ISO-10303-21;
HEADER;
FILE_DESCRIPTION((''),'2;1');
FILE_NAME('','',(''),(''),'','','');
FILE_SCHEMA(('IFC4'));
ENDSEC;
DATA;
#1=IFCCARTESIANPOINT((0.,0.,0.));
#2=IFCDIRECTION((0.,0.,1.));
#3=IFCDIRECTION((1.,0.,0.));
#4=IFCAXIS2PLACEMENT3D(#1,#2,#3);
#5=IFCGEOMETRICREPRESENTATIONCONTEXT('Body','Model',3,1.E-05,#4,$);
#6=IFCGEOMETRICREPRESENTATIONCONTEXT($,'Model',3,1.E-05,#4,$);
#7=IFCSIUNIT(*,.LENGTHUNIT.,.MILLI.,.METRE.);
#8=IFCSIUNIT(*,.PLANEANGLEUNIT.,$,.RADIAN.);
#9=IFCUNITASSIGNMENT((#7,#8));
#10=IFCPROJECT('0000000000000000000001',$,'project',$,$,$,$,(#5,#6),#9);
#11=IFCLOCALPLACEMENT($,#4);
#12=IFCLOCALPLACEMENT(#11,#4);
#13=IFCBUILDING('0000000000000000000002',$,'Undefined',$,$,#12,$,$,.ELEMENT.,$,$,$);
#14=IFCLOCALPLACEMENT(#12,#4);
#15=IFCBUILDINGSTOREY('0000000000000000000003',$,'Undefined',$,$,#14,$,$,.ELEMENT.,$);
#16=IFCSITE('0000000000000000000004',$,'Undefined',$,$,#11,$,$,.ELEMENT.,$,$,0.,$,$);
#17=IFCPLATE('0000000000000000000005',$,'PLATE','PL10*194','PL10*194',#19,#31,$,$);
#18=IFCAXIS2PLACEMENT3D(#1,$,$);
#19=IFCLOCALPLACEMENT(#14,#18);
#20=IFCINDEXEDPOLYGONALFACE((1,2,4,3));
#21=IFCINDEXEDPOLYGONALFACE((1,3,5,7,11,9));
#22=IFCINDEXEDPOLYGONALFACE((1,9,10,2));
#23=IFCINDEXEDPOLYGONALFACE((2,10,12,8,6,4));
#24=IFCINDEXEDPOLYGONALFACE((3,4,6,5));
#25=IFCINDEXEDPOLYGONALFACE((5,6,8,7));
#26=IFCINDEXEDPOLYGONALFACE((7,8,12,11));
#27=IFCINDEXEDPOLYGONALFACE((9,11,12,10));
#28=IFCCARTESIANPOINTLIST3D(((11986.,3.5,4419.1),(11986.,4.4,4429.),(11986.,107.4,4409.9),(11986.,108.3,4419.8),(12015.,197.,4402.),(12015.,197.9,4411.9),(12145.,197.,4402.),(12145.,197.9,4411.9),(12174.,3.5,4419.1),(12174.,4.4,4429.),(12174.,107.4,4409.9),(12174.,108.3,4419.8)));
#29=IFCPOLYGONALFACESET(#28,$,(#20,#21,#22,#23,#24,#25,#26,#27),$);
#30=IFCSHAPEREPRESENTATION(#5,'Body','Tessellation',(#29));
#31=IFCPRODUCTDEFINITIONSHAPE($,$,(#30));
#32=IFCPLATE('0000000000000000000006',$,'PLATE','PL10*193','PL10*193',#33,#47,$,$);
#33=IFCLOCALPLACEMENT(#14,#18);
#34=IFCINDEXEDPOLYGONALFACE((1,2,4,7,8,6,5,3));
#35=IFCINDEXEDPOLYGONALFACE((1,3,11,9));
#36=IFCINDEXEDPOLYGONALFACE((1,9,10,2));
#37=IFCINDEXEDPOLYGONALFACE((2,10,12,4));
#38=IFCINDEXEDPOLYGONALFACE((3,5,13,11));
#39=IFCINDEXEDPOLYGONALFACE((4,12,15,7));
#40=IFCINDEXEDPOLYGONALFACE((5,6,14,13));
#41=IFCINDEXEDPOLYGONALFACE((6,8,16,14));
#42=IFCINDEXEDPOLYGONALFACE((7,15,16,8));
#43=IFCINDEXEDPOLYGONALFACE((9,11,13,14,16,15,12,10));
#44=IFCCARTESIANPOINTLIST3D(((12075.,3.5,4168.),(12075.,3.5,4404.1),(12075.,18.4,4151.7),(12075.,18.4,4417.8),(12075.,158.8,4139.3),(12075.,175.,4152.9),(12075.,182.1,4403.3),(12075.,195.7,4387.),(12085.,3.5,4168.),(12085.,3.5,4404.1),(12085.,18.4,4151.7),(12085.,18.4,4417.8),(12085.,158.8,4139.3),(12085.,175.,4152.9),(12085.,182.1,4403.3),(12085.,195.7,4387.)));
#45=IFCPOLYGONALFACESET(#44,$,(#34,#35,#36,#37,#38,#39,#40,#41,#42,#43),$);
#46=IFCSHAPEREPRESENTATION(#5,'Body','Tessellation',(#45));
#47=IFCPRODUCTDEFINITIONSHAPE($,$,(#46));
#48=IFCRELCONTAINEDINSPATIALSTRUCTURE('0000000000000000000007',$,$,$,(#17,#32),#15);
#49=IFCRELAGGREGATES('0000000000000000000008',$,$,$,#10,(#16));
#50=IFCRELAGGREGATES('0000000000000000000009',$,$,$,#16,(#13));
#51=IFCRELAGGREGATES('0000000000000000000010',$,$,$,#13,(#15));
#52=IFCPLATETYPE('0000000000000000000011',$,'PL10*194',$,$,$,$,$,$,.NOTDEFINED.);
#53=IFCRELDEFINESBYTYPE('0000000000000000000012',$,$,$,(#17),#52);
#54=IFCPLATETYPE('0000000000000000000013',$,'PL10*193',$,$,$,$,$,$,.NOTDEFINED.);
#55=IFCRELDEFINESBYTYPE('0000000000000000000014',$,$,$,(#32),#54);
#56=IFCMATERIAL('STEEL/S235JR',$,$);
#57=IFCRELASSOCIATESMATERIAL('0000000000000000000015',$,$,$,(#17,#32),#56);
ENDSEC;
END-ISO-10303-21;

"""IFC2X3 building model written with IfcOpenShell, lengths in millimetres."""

from ifc_helpers import new_model, si_unit, frame, origin_with_axes, place, context, project, spatial, polyline, outline, extrude, material, type_object, element, save


model = new_model("IFC2X3")

# Units and contexts
model_context_1 = context("Model", 3, precision=1e-05, world=origin_with_axes(), identifier="Body")
model_context_2 = context("Model", 3, precision=1e-05, world=origin_with_axes())
ifc_project = project(units=[si_unit("LENGTHUNIT", "METRE", prefix="MILLI"), si_unit("PLANEANGLEUNIT", "RADIAN")], contexts=[model_context_1, model_context_2])

# Site, building, storey
site_placement = place(None, origin_with_axes())
site = spatial("IfcSite", under=ifc_project, at=site_placement, Name="Undefined", CompositionType="ELEMENT", RefElevation=0.0)
building_placement = place(site_placement, origin_with_axes())
building = spatial("IfcBuilding", under=site, at=building_placement, Name="Undefined", CompositionType="ELEMENT")
storey_placement = place(building_placement, origin_with_axes())
storey = spatial("IfcBuildingStorey", under=building, at=storey_placement, Name="Undefined", CompositionType="ELEMENT")

# Shared definitions
ifc_material = material(Name="STEEL/S235JR")

# Plates
plate_type_1 = type_object("IfcPlateType", Name="PL10*194", PredefinedType="NOTDEFINED")
plate_1_placement = place(storey_placement, frame((12145.0, 197.5, 4406.9), z_axis=(0.0, -0.08801, -0.99612), x_axis=(0.306693, -0.948115, 0.083768)))
element("IfcPlate", 1, at=plate_1_placement, inside=storey, type_object=plate_type_1, material=ifc_material, Name="PLATE", Description="PL10*194", ObjectType="PL10*194", context=model_context_1, shape_type="SweptSolid", body=[
    extrude(outline(polyline([(0.0, 0.0), (94.6, 0.0), (193.8, 32.0), (136.2, 210.9), (36.9, 178.9), (-39.9, 123.7), (0.0, 0.0)])), frame((0.0, 0.0, -5.0), z_axis=(0.0, 0.0, 1.0), x_axis=(1.0, 0.0, 0.0)), (0.0, 0.0, 1.0), 10.0),
])
plate_type_2 = type_object("IfcPlateType", Name="PL10*193", PredefinedType="NOTDEFINED")
plate_2_placement = place(storey_placement, frame((12080.0, 3.5, 4419.1), z_axis=(-1.0, 0.0, 0.0), x_axis=(0.0, 0.996098, -0.088258)))
element("IfcPlate", 2, at=plate_2_placement, inside=storey, type_object=plate_type_2, material=ifc_material, Name="PLATE", Description="PL10*193", ObjectType="PL10*193", context=model_context_1, shape_type="SweptSolid", body=[
    extrude(outline(polyline([(1.3, 14.9), (15.0, 0.0), (179.3, 0.0), (194.3, 15.0), (194.4, 250.0), (179.4, 265.0), (38.5, 265.0), (22.2, 250.1), (1.3, 14.9)])), frame((0.0, 0.0, -5.0), z_axis=(0.0, 0.0, 1.0), x_axis=(1.0, 0.0, 0.0)), (0.0, 0.0, 1.0), 10.0),
])

save(model, "model.ifc")
